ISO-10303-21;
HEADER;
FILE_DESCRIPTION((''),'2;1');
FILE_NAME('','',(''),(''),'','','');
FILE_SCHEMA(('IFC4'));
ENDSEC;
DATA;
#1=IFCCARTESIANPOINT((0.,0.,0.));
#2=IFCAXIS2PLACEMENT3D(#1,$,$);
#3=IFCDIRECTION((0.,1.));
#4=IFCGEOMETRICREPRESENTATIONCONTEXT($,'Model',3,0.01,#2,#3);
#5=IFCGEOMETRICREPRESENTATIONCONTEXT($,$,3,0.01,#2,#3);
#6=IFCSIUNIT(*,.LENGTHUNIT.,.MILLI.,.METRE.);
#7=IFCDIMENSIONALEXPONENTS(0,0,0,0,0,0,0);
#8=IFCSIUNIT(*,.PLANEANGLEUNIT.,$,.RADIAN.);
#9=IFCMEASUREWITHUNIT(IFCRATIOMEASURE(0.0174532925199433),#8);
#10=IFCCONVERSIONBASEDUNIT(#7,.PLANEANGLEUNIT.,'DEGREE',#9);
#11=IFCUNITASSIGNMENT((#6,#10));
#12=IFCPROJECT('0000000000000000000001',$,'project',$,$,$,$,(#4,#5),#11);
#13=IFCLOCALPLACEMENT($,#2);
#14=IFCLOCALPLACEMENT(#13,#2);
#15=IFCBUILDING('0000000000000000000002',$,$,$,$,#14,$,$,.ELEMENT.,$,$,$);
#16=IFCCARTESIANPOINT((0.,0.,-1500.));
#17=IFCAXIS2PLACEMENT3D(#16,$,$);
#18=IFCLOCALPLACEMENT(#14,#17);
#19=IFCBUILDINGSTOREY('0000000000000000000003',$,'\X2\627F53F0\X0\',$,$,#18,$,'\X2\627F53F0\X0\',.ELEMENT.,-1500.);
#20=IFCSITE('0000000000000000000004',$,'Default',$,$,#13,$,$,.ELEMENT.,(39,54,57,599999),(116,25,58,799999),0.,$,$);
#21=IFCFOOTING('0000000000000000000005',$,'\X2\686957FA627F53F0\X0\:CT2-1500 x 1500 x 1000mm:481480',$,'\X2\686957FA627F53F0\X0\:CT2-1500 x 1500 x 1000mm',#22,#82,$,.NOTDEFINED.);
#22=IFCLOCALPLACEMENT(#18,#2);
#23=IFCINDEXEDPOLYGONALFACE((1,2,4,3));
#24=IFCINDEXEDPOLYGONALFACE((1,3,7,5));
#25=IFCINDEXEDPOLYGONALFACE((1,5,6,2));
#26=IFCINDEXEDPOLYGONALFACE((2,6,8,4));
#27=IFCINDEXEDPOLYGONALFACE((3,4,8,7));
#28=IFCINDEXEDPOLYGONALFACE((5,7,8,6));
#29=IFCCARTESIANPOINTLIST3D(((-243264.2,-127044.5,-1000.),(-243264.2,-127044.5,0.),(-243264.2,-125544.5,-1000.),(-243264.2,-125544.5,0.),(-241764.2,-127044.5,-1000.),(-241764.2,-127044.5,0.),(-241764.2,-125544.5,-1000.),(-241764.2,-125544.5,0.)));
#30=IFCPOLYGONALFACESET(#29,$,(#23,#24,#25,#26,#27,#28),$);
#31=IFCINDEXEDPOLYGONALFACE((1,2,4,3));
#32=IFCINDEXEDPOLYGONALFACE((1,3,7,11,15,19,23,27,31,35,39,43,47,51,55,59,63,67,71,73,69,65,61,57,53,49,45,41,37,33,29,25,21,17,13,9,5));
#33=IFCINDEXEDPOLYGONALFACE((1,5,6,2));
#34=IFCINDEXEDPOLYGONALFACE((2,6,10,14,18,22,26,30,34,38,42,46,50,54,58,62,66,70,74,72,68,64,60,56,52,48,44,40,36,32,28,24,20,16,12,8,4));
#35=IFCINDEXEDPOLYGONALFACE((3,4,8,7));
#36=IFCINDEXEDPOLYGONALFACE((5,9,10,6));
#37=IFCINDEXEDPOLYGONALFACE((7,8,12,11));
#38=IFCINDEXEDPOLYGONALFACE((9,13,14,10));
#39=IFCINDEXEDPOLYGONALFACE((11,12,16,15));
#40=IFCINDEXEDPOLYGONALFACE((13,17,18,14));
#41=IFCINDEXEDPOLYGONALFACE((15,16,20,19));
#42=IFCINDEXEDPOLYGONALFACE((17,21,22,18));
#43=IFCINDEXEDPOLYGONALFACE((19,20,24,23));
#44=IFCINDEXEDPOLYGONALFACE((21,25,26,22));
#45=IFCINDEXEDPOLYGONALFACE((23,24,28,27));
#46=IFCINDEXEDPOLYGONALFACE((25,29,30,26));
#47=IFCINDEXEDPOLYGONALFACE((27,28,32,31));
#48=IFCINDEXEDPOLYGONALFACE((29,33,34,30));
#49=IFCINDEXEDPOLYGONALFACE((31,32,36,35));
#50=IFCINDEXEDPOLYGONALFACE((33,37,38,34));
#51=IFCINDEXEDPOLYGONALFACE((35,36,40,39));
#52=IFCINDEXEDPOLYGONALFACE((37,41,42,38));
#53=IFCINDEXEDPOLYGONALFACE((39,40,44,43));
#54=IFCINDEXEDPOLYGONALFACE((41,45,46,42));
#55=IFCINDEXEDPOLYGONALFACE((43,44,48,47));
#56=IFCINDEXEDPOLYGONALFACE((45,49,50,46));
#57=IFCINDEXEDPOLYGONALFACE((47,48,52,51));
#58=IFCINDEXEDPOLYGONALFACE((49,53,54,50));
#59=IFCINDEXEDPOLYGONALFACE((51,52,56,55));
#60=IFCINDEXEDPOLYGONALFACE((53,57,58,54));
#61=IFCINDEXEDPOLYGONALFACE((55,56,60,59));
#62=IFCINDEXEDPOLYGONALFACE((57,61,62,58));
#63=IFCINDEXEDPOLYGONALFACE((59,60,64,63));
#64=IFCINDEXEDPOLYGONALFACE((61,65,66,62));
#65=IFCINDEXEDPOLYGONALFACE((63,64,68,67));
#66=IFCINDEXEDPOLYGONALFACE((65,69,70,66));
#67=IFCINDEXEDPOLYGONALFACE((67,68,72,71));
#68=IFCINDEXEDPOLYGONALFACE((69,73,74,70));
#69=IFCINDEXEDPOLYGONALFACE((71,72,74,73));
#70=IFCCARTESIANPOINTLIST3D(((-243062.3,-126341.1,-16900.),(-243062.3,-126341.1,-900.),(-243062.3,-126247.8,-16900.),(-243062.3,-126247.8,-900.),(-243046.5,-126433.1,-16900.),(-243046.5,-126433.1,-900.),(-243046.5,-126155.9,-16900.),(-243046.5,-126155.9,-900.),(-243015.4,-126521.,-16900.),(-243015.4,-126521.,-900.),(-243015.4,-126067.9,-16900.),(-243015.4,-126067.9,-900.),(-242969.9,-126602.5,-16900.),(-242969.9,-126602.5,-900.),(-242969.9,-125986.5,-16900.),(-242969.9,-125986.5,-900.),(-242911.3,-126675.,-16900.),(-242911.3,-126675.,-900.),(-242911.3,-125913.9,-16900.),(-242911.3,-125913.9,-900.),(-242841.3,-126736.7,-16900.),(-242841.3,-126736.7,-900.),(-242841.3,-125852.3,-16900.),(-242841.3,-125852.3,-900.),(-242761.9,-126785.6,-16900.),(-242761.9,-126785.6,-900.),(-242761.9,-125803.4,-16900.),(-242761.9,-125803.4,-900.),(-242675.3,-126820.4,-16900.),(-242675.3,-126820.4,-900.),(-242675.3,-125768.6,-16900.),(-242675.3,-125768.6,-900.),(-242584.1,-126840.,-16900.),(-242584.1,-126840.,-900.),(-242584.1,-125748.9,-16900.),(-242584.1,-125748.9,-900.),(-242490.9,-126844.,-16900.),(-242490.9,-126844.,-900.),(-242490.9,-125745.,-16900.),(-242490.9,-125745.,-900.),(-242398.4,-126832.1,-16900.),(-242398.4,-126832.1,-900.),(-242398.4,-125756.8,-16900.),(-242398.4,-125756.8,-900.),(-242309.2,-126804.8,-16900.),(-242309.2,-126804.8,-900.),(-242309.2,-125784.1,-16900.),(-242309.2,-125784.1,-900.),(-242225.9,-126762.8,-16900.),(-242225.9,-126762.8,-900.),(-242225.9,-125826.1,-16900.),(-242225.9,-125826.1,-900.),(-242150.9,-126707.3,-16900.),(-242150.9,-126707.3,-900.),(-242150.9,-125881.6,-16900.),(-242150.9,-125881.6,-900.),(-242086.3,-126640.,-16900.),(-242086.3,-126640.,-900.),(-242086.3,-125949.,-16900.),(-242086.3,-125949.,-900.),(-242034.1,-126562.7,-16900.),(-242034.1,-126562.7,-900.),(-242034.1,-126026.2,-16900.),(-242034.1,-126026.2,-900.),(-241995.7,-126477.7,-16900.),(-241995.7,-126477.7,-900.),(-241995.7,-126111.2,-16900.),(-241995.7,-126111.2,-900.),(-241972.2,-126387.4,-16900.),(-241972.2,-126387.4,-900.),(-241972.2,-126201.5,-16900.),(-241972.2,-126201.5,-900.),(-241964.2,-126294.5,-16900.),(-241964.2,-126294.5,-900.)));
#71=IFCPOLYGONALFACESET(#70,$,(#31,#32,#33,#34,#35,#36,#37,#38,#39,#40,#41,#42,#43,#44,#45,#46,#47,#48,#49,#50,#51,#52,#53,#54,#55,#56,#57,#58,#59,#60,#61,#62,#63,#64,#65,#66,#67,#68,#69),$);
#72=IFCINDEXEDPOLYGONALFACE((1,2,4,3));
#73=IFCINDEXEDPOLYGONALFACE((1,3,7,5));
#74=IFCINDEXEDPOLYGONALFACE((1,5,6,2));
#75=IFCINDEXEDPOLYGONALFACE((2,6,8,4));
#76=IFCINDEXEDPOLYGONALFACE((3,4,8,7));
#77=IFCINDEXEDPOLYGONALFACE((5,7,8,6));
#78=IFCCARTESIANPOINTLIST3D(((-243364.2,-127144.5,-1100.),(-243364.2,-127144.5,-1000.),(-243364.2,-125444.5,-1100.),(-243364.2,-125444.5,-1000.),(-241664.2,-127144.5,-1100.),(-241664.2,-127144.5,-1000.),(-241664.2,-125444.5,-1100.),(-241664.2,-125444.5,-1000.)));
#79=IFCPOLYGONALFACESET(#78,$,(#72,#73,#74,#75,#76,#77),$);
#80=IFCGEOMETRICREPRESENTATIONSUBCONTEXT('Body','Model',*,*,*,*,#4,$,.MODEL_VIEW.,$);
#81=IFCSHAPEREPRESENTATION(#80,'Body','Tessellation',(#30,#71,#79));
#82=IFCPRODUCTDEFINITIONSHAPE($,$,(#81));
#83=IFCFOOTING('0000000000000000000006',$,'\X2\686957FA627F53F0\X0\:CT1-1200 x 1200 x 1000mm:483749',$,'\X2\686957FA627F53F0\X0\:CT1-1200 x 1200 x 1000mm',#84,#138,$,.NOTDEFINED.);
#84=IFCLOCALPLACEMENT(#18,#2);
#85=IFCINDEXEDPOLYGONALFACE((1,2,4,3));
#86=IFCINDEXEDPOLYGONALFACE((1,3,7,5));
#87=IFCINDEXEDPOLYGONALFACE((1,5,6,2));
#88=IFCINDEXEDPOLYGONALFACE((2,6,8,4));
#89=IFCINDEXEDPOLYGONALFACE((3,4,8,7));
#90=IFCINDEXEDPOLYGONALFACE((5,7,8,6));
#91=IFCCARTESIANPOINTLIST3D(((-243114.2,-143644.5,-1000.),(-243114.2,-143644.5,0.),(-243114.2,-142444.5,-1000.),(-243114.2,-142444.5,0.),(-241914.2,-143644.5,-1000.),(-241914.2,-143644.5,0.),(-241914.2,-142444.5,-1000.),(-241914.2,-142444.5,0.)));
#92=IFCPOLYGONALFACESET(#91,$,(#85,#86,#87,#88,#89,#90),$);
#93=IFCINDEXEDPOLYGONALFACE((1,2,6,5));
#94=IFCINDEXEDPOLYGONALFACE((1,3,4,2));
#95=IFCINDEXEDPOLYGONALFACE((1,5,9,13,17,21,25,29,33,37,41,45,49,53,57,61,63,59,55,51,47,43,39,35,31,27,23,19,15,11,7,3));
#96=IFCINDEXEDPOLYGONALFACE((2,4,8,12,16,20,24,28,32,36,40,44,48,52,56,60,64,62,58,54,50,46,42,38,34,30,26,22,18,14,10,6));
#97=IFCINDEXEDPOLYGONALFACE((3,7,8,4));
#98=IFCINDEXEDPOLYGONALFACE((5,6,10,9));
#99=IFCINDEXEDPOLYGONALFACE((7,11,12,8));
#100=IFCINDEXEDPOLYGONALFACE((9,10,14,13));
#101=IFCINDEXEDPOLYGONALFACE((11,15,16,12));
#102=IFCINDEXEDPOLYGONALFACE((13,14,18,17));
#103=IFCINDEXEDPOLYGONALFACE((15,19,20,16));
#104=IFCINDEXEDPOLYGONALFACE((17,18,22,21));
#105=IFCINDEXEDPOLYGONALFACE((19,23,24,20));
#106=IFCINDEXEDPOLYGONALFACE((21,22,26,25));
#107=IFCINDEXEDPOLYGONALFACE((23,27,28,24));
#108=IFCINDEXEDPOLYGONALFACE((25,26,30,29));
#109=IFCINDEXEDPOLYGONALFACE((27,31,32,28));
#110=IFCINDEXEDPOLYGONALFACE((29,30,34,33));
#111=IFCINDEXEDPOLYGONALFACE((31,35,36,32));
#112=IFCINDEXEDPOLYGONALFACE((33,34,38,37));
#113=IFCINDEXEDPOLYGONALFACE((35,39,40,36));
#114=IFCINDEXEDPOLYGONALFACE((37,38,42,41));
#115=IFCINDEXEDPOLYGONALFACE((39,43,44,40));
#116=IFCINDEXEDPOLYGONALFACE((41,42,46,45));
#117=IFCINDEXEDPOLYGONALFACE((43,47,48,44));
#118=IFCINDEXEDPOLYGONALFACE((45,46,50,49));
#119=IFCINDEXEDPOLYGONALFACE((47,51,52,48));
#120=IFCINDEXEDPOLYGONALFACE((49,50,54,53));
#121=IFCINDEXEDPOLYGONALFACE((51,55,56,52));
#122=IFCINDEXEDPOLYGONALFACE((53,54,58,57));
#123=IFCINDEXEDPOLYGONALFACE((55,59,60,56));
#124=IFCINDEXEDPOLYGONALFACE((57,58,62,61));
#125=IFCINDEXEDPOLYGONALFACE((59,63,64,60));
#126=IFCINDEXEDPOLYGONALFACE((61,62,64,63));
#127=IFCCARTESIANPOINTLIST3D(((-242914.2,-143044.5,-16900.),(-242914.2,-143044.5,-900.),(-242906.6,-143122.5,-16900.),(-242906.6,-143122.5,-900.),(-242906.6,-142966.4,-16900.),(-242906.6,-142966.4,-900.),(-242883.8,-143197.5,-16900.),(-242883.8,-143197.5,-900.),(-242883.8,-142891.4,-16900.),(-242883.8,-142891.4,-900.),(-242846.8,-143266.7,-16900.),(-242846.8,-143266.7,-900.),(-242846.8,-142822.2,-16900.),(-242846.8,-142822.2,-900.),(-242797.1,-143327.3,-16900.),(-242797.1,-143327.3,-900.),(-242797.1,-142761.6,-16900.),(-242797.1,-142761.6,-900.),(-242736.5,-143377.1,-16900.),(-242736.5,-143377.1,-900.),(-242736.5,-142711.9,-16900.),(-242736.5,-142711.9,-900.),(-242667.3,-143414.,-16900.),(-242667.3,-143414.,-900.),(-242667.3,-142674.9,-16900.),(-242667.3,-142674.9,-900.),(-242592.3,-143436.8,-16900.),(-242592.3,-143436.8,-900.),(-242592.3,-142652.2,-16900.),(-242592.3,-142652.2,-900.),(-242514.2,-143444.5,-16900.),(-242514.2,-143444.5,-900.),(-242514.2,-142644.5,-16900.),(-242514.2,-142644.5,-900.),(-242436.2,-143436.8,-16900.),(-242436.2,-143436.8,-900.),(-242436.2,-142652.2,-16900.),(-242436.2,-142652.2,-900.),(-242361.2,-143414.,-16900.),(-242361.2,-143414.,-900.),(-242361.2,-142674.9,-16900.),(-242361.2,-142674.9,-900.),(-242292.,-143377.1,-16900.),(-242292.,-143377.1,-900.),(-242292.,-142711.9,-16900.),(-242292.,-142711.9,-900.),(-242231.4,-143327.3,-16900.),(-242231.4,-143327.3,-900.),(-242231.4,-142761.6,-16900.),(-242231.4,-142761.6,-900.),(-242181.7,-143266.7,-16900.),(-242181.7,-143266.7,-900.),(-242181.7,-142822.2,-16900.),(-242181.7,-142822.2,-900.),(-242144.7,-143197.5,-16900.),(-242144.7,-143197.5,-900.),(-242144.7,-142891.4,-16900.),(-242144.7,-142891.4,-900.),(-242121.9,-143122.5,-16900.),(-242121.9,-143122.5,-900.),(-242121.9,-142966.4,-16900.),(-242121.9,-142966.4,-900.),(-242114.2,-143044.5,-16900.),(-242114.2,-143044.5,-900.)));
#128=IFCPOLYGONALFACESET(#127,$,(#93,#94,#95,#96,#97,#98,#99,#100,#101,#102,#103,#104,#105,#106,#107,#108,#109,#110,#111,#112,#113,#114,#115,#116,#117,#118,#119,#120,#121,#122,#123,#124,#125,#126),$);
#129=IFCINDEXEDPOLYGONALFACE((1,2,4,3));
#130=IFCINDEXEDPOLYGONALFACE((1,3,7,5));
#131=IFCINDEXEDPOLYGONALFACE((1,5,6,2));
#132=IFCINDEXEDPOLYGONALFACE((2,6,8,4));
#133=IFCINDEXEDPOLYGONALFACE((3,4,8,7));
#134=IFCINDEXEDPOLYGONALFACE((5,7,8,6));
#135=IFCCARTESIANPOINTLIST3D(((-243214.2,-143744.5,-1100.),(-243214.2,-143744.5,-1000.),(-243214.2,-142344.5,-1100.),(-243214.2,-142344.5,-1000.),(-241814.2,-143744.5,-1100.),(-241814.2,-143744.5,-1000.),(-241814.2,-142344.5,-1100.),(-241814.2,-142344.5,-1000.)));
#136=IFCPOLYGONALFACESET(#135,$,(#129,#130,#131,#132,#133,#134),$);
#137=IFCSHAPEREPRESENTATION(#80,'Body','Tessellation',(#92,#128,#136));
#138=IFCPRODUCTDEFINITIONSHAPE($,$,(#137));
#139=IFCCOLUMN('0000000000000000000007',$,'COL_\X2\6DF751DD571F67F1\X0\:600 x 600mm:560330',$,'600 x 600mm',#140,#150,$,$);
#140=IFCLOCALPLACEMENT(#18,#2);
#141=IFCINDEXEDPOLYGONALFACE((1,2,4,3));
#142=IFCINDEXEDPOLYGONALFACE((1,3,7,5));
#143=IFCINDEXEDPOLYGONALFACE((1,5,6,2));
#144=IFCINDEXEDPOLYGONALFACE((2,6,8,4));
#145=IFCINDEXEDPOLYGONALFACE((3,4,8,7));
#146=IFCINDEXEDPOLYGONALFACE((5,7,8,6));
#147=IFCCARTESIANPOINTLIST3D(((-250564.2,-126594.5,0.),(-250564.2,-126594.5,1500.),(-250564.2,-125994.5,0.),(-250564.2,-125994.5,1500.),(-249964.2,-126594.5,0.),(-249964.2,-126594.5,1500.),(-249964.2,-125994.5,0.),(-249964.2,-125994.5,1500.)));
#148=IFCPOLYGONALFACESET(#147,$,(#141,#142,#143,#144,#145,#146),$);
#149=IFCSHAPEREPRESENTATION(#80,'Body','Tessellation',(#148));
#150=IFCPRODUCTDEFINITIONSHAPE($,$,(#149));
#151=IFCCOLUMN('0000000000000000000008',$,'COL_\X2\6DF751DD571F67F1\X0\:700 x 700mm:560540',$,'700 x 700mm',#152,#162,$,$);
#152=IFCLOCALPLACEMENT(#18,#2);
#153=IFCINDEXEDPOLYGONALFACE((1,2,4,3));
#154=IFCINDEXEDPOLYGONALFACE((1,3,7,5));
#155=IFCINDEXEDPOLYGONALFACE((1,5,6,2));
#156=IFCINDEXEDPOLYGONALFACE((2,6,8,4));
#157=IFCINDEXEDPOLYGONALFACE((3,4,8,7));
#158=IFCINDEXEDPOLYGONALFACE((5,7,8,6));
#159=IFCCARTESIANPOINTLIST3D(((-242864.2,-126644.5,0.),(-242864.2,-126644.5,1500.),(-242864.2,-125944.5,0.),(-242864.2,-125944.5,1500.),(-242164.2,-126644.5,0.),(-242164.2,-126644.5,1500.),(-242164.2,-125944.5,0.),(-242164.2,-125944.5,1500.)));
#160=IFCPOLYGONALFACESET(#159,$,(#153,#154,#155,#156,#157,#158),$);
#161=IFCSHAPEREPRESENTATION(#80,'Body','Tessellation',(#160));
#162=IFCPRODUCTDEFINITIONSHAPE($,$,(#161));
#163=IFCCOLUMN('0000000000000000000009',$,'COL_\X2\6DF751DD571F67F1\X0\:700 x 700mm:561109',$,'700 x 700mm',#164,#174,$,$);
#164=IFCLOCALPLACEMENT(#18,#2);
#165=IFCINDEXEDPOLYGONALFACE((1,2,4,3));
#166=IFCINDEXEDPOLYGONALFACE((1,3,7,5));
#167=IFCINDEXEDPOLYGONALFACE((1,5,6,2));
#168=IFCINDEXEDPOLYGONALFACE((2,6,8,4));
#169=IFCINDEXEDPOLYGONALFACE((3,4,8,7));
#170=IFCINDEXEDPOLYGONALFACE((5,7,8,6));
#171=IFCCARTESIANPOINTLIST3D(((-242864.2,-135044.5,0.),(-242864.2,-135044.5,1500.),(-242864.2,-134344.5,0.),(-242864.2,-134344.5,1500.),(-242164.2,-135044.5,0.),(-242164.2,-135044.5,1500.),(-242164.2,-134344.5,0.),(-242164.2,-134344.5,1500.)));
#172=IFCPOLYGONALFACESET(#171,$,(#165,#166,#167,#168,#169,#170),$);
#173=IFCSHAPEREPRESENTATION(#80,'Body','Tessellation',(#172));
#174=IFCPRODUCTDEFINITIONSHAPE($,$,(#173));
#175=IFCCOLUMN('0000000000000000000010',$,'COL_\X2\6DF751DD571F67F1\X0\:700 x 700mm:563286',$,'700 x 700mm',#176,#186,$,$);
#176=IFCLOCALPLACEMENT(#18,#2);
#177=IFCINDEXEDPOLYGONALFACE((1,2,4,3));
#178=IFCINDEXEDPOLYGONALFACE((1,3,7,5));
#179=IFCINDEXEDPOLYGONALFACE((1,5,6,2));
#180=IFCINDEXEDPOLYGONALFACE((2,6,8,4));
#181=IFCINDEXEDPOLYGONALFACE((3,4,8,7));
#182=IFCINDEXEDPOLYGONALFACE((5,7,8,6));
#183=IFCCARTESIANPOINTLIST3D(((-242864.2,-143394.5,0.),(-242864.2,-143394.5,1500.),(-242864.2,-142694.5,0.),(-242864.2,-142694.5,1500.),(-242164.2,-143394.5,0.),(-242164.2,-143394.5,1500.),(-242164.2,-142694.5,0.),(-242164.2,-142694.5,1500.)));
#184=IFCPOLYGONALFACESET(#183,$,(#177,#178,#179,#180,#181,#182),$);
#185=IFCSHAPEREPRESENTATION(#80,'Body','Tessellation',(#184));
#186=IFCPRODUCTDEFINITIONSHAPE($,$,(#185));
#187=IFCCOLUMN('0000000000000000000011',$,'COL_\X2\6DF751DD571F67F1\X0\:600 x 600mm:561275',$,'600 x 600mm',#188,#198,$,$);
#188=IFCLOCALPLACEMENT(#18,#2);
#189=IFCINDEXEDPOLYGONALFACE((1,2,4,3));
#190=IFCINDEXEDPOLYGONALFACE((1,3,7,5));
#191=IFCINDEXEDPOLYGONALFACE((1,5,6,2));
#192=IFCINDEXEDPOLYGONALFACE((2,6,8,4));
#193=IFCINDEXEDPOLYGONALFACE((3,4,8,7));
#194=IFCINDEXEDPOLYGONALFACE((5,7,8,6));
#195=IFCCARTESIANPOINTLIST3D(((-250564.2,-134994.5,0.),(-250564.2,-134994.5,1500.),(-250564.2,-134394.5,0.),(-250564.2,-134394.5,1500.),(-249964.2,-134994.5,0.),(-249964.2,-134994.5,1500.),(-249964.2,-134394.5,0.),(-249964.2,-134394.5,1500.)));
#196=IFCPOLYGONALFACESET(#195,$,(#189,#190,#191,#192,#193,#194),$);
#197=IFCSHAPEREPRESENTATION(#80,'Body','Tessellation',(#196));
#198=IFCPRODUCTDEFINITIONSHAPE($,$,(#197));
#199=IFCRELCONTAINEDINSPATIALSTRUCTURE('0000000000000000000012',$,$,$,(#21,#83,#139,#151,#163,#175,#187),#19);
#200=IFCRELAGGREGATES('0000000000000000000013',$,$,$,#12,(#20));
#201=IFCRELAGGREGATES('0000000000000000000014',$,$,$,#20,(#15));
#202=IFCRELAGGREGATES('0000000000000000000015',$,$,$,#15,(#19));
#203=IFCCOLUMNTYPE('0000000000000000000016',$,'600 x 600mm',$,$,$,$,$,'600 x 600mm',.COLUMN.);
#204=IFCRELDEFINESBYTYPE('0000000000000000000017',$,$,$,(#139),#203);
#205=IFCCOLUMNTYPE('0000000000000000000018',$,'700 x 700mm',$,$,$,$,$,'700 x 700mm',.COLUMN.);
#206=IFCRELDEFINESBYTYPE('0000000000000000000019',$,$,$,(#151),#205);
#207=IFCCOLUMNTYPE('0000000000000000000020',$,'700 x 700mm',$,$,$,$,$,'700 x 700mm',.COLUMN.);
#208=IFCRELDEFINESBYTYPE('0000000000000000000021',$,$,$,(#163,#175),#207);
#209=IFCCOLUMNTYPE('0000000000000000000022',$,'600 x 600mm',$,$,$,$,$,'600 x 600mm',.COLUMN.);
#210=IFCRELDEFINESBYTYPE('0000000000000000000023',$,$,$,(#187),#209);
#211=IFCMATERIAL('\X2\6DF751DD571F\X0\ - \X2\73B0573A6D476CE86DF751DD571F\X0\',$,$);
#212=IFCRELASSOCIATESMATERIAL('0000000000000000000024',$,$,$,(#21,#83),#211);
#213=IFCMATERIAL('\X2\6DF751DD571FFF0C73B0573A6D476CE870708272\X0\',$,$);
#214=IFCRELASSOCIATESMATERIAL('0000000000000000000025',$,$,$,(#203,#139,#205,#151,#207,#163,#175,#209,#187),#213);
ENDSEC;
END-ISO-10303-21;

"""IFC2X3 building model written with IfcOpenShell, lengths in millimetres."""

from ifc_helpers import new_model, entity, si_unit, converted_unit, direction, frame, frame_2d, origin, origin_2d_with_axis, place, context, subcontext, project, spatial, rectangle, circle, extrude, source, transform, mapped, material, type_object, type_shapes, element, save


model = new_model("IFC2X3")

# Units and contexts
model_context = context("Model", 3, precision=0.01, world=origin(), true_north=direction((0.0, 1.0)))
context_of_model = context(None, 3, precision=0.01, world=origin(), true_north=direction((0.0, 1.0)))
body_context = subcontext(model_context, "Body", "Model", "MODEL_VIEW")
ifc_project = project(units=[si_unit("LENGTHUNIT", "METRE", prefix="MILLI"), converted_unit("PLANEANGLEUNIT", "DEGREE", entity("IfcRatioMeasure", 0.0174532925199433), si_unit("PLANEANGLEUNIT", "RADIAN"), dimensions=[0, 0, 0, 0, 0, 0, 0])], contexts=[model_context, context_of_model])

# Site, building, storey
site_placement = place(None, origin())
site = spatial("IfcSite", under=ifc_project, at=site_placement, Name="Default", CompositionType="ELEMENT", RefLatitude=(39, 54, 57, 599999), RefLongitude=(116, 25, 58, 799999), RefElevation=0.0)
building_placement = place(site_placement, origin())
building = spatial("IfcBuilding", under=site, at=building_placement, CompositionType="ELEMENT")
storey_placement = place(building_placement, frame((0.0, 0.0, -1500.0)))
storey = spatial("IfcBuildingStorey", under=building, at=storey_placement, Name="承台", LongName="承台", CompositionType="ELEMENT", Elevation=-1500.0)

# Footings
ifc_material_1 = material(Name="混凝土 - 现场浇注混凝土")
footing_1_placement = place(storey_placement, frame((-243364.2, -127144.5, -16900.0)))
element("IfcFooting", 1, at=footing_1_placement, inside=storey, material=ifc_material_1, Name="桩基承台:CT2-1500 x 1500 x 1000mm:481480", ObjectType="桩基承台:CT2-1500 x 1500 x 1000mm", PredefinedType="NOTDEFINED", context=body_context, shape_type="SweptSolid", body=[
    extrude(rectangle(XDim=1500.0, YDim=1500.0, at=origin_2d_with_axis()), frame((850.0, 850.0, 15900.0), z_axis=(0.0, 0.0, 1.0), x_axis=(-1.0, 0.0, 0.0)), (0.0, 0.0, 1.0), 1000.0),
    extrude(circle(Radius=550.0, at=origin_2d_with_axis()), frame((850.0, 850.0, 0.0)), (0.0, 0.0, 1.0), 16000.0),
    extrude(rectangle(XDim=1700.0, YDim=1700.0, at=frame_2d((0.0, 0.0), x_axis=(1.0, 0.0))), frame((850.0, 850.0, 15800.0), z_axis=(0.0, 0.0, 1.0), x_axis=(0.0, 1.0, 0.0)), (0.0, 0.0, 1.0), 100.0),
])
footing_2_placement = place(storey_placement, frame((-243214.2, -143744.5, -16900.0)))
element("IfcFooting", 2, at=footing_2_placement, inside=storey, material=ifc_material_1, Name="桩基承台:CT1-1200 x 1200 x 1000mm:483749", ObjectType="桩基承台:CT1-1200 x 1200 x 1000mm", PredefinedType="NOTDEFINED", context=body_context, shape_type="SweptSolid", body=[
    extrude(rectangle(XDim=1200.0, YDim=1200.0, at=frame_2d((200.0, -66.7), x_axis=(1.0, 0.0))), frame((900.0, 633.3, 15900.0), z_axis=(0.0, 0.0, 1.0), x_axis=(-1.0, 0.0, 0.0)), (0.0, 0.0, 1.0), 1000.0),
    extrude(circle(Radius=400.0, at=origin_2d_with_axis()), frame((700.0, 700.0, 0.0)), (0.0, 0.0, 1.0), 16000.0),
    extrude(rectangle(XDim=1400.0, YDim=1400.0, at=frame_2d((0.0, 0.0), x_axis=(1.0, 0.0))), frame((700.0, 700.0, 15800.0), z_axis=(0.0, 0.0, 1.0), x_axis=(0.0, 1.0, 0.0)), (0.0, 0.0, 1.0), 100.0),
])

# Columns
ifc_material_2 = material(Name="混凝土，现场浇注灰色")
column_type_1 = type_object("IfcColumnType", Name="600 x 600mm", ElementType="600 x 600mm", PredefinedType="COLUMN", material=ifc_material_2)
shared_shape_1 = source(origin(), body_context, "Body", "SweptSolid", [
    extrude(rectangle(XDim=600.0, YDim=600.0, at=origin_2d_with_axis()), frame((300.0, 300.0, 0.0), z_axis=(0.0, 0.0, 1.0), x_axis=(-1.0, 0.0, 0.0)), (0.0, 0.0, 1.0), 1500.0),
])
type_shapes(column_type_1, [shared_shape_1])
column_1_placement = place(storey_placement, frame((-250564.2, -126594.5, 0.0)))
element("IfcColumn", 3, at=column_1_placement, inside=storey, type_object=column_type_1, material=ifc_material_2, Name="COL_混凝土柱:600 x 600mm:560330", ObjectType="600 x 600mm", context=body_context, shape_type="MappedRepresentation", body=[
    mapped(shared_shape_1, transform((0.0, 0.0, 0.0), scale=1.0)),
])
column_type_2 = type_object("IfcColumnType", Name="700 x 700mm", ElementType="700 x 700mm", PredefinedType="COLUMN", material=ifc_material_2)
shared_shape_2 = source(origin(), body_context, "Body", "SweptSolid", [
    extrude(rectangle(XDim=700.0, YDim=700.0, at=frame_2d((0.0, 0.0), x_axis=(1.0, 0.0))), frame((350.0, 350.0, 0.0), z_axis=(0.0, 0.0, 1.0), x_axis=(-1.0, 0.0, 0.0)), (0.0, 0.0, 1.0), 1500.0),
])
type_shapes(column_type_2, [shared_shape_2])
column_2_placement = place(storey_placement, frame((-242864.2, -126644.5, 0.0)))
element("IfcColumn", 4, at=column_2_placement, inside=storey, type_object=column_type_2, material=ifc_material_2, Name="COL_混凝土柱:700 x 700mm:560540", ObjectType="700 x 700mm", context=body_context, shape_type="MappedRepresentation", body=[
    mapped(shared_shape_2, transform((0.0, 0.0, 0.0), scale=1.0)),
])
column_type_3 = type_object("IfcColumnType", Name="700 x 700mm", ElementType="700 x 700mm", PredefinedType="COLUMN", material=ifc_material_2)
shared_shape_3 = source(origin(), body_context, "Body", "SweptSolid", [
    extrude(rectangle(XDim=700.0, YDim=700.0, at=origin_2d_with_axis()), frame((0.0, 0.0, -1500.0), z_axis=(0.0, 0.0, 1.0), x_axis=(-1.0, 0.0, 0.0)), (0.0, 0.0, 1.0), 1500.0),
])
type_shapes(column_type_3, [shared_shape_3])
for number, where, name in (
    (5, (-242514.2, -134694.5, 1500.0), "COL_混凝土柱:700 x 700mm:561109"),
    (6, (-242514.2, -143044.5, 1500.0), "COL_混凝土柱:700 x 700mm:563286"),
):
    element("IfcColumn", number, at=place(storey_placement, frame(where)), inside=storey, type_object=column_type_3, material=ifc_material_2, Name=name, ObjectType="700 x 700mm", context=body_context, shape_type="MappedRepresentation", body=[
        mapped(shared_shape_3, transform((0.0, 0.0, 0.0), scale=1.0)),
    ])
column_type_4 = type_object("IfcColumnType", Name="600 x 600mm", ElementType="600 x 600mm", PredefinedType="COLUMN", material=ifc_material_2)
shared_shape_4 = source(origin(), body_context, "Body", "SweptSolid", [
    extrude(rectangle(XDim=600.0, YDim=600.0, at=origin_2d_with_axis()), frame((0.0, 0.0, -1500.0), z_axis=(0.0, 0.0, 1.0), x_axis=(-1.0, 0.0, 0.0)), (0.0, 0.0, 1.0), 1500.0),
])
type_shapes(column_type_4, [shared_shape_4])
for number, where, name in (
    (7, (-250264.2, -134694.5, 1500.0), "COL_混凝土柱:600 x 600mm:561275"),
):
    element("IfcColumn", number, at=place(storey_placement, frame(where)), inside=storey, type_object=column_type_4, material=ifc_material_2, Name=name, ObjectType="600 x 600mm", context=body_context, shape_type="MappedRepresentation", body=[
        mapped(shared_shape_4, transform((0.0, 0.0, 0.0), scale=1.0)),
    ])

save(model, "model.ifc")
